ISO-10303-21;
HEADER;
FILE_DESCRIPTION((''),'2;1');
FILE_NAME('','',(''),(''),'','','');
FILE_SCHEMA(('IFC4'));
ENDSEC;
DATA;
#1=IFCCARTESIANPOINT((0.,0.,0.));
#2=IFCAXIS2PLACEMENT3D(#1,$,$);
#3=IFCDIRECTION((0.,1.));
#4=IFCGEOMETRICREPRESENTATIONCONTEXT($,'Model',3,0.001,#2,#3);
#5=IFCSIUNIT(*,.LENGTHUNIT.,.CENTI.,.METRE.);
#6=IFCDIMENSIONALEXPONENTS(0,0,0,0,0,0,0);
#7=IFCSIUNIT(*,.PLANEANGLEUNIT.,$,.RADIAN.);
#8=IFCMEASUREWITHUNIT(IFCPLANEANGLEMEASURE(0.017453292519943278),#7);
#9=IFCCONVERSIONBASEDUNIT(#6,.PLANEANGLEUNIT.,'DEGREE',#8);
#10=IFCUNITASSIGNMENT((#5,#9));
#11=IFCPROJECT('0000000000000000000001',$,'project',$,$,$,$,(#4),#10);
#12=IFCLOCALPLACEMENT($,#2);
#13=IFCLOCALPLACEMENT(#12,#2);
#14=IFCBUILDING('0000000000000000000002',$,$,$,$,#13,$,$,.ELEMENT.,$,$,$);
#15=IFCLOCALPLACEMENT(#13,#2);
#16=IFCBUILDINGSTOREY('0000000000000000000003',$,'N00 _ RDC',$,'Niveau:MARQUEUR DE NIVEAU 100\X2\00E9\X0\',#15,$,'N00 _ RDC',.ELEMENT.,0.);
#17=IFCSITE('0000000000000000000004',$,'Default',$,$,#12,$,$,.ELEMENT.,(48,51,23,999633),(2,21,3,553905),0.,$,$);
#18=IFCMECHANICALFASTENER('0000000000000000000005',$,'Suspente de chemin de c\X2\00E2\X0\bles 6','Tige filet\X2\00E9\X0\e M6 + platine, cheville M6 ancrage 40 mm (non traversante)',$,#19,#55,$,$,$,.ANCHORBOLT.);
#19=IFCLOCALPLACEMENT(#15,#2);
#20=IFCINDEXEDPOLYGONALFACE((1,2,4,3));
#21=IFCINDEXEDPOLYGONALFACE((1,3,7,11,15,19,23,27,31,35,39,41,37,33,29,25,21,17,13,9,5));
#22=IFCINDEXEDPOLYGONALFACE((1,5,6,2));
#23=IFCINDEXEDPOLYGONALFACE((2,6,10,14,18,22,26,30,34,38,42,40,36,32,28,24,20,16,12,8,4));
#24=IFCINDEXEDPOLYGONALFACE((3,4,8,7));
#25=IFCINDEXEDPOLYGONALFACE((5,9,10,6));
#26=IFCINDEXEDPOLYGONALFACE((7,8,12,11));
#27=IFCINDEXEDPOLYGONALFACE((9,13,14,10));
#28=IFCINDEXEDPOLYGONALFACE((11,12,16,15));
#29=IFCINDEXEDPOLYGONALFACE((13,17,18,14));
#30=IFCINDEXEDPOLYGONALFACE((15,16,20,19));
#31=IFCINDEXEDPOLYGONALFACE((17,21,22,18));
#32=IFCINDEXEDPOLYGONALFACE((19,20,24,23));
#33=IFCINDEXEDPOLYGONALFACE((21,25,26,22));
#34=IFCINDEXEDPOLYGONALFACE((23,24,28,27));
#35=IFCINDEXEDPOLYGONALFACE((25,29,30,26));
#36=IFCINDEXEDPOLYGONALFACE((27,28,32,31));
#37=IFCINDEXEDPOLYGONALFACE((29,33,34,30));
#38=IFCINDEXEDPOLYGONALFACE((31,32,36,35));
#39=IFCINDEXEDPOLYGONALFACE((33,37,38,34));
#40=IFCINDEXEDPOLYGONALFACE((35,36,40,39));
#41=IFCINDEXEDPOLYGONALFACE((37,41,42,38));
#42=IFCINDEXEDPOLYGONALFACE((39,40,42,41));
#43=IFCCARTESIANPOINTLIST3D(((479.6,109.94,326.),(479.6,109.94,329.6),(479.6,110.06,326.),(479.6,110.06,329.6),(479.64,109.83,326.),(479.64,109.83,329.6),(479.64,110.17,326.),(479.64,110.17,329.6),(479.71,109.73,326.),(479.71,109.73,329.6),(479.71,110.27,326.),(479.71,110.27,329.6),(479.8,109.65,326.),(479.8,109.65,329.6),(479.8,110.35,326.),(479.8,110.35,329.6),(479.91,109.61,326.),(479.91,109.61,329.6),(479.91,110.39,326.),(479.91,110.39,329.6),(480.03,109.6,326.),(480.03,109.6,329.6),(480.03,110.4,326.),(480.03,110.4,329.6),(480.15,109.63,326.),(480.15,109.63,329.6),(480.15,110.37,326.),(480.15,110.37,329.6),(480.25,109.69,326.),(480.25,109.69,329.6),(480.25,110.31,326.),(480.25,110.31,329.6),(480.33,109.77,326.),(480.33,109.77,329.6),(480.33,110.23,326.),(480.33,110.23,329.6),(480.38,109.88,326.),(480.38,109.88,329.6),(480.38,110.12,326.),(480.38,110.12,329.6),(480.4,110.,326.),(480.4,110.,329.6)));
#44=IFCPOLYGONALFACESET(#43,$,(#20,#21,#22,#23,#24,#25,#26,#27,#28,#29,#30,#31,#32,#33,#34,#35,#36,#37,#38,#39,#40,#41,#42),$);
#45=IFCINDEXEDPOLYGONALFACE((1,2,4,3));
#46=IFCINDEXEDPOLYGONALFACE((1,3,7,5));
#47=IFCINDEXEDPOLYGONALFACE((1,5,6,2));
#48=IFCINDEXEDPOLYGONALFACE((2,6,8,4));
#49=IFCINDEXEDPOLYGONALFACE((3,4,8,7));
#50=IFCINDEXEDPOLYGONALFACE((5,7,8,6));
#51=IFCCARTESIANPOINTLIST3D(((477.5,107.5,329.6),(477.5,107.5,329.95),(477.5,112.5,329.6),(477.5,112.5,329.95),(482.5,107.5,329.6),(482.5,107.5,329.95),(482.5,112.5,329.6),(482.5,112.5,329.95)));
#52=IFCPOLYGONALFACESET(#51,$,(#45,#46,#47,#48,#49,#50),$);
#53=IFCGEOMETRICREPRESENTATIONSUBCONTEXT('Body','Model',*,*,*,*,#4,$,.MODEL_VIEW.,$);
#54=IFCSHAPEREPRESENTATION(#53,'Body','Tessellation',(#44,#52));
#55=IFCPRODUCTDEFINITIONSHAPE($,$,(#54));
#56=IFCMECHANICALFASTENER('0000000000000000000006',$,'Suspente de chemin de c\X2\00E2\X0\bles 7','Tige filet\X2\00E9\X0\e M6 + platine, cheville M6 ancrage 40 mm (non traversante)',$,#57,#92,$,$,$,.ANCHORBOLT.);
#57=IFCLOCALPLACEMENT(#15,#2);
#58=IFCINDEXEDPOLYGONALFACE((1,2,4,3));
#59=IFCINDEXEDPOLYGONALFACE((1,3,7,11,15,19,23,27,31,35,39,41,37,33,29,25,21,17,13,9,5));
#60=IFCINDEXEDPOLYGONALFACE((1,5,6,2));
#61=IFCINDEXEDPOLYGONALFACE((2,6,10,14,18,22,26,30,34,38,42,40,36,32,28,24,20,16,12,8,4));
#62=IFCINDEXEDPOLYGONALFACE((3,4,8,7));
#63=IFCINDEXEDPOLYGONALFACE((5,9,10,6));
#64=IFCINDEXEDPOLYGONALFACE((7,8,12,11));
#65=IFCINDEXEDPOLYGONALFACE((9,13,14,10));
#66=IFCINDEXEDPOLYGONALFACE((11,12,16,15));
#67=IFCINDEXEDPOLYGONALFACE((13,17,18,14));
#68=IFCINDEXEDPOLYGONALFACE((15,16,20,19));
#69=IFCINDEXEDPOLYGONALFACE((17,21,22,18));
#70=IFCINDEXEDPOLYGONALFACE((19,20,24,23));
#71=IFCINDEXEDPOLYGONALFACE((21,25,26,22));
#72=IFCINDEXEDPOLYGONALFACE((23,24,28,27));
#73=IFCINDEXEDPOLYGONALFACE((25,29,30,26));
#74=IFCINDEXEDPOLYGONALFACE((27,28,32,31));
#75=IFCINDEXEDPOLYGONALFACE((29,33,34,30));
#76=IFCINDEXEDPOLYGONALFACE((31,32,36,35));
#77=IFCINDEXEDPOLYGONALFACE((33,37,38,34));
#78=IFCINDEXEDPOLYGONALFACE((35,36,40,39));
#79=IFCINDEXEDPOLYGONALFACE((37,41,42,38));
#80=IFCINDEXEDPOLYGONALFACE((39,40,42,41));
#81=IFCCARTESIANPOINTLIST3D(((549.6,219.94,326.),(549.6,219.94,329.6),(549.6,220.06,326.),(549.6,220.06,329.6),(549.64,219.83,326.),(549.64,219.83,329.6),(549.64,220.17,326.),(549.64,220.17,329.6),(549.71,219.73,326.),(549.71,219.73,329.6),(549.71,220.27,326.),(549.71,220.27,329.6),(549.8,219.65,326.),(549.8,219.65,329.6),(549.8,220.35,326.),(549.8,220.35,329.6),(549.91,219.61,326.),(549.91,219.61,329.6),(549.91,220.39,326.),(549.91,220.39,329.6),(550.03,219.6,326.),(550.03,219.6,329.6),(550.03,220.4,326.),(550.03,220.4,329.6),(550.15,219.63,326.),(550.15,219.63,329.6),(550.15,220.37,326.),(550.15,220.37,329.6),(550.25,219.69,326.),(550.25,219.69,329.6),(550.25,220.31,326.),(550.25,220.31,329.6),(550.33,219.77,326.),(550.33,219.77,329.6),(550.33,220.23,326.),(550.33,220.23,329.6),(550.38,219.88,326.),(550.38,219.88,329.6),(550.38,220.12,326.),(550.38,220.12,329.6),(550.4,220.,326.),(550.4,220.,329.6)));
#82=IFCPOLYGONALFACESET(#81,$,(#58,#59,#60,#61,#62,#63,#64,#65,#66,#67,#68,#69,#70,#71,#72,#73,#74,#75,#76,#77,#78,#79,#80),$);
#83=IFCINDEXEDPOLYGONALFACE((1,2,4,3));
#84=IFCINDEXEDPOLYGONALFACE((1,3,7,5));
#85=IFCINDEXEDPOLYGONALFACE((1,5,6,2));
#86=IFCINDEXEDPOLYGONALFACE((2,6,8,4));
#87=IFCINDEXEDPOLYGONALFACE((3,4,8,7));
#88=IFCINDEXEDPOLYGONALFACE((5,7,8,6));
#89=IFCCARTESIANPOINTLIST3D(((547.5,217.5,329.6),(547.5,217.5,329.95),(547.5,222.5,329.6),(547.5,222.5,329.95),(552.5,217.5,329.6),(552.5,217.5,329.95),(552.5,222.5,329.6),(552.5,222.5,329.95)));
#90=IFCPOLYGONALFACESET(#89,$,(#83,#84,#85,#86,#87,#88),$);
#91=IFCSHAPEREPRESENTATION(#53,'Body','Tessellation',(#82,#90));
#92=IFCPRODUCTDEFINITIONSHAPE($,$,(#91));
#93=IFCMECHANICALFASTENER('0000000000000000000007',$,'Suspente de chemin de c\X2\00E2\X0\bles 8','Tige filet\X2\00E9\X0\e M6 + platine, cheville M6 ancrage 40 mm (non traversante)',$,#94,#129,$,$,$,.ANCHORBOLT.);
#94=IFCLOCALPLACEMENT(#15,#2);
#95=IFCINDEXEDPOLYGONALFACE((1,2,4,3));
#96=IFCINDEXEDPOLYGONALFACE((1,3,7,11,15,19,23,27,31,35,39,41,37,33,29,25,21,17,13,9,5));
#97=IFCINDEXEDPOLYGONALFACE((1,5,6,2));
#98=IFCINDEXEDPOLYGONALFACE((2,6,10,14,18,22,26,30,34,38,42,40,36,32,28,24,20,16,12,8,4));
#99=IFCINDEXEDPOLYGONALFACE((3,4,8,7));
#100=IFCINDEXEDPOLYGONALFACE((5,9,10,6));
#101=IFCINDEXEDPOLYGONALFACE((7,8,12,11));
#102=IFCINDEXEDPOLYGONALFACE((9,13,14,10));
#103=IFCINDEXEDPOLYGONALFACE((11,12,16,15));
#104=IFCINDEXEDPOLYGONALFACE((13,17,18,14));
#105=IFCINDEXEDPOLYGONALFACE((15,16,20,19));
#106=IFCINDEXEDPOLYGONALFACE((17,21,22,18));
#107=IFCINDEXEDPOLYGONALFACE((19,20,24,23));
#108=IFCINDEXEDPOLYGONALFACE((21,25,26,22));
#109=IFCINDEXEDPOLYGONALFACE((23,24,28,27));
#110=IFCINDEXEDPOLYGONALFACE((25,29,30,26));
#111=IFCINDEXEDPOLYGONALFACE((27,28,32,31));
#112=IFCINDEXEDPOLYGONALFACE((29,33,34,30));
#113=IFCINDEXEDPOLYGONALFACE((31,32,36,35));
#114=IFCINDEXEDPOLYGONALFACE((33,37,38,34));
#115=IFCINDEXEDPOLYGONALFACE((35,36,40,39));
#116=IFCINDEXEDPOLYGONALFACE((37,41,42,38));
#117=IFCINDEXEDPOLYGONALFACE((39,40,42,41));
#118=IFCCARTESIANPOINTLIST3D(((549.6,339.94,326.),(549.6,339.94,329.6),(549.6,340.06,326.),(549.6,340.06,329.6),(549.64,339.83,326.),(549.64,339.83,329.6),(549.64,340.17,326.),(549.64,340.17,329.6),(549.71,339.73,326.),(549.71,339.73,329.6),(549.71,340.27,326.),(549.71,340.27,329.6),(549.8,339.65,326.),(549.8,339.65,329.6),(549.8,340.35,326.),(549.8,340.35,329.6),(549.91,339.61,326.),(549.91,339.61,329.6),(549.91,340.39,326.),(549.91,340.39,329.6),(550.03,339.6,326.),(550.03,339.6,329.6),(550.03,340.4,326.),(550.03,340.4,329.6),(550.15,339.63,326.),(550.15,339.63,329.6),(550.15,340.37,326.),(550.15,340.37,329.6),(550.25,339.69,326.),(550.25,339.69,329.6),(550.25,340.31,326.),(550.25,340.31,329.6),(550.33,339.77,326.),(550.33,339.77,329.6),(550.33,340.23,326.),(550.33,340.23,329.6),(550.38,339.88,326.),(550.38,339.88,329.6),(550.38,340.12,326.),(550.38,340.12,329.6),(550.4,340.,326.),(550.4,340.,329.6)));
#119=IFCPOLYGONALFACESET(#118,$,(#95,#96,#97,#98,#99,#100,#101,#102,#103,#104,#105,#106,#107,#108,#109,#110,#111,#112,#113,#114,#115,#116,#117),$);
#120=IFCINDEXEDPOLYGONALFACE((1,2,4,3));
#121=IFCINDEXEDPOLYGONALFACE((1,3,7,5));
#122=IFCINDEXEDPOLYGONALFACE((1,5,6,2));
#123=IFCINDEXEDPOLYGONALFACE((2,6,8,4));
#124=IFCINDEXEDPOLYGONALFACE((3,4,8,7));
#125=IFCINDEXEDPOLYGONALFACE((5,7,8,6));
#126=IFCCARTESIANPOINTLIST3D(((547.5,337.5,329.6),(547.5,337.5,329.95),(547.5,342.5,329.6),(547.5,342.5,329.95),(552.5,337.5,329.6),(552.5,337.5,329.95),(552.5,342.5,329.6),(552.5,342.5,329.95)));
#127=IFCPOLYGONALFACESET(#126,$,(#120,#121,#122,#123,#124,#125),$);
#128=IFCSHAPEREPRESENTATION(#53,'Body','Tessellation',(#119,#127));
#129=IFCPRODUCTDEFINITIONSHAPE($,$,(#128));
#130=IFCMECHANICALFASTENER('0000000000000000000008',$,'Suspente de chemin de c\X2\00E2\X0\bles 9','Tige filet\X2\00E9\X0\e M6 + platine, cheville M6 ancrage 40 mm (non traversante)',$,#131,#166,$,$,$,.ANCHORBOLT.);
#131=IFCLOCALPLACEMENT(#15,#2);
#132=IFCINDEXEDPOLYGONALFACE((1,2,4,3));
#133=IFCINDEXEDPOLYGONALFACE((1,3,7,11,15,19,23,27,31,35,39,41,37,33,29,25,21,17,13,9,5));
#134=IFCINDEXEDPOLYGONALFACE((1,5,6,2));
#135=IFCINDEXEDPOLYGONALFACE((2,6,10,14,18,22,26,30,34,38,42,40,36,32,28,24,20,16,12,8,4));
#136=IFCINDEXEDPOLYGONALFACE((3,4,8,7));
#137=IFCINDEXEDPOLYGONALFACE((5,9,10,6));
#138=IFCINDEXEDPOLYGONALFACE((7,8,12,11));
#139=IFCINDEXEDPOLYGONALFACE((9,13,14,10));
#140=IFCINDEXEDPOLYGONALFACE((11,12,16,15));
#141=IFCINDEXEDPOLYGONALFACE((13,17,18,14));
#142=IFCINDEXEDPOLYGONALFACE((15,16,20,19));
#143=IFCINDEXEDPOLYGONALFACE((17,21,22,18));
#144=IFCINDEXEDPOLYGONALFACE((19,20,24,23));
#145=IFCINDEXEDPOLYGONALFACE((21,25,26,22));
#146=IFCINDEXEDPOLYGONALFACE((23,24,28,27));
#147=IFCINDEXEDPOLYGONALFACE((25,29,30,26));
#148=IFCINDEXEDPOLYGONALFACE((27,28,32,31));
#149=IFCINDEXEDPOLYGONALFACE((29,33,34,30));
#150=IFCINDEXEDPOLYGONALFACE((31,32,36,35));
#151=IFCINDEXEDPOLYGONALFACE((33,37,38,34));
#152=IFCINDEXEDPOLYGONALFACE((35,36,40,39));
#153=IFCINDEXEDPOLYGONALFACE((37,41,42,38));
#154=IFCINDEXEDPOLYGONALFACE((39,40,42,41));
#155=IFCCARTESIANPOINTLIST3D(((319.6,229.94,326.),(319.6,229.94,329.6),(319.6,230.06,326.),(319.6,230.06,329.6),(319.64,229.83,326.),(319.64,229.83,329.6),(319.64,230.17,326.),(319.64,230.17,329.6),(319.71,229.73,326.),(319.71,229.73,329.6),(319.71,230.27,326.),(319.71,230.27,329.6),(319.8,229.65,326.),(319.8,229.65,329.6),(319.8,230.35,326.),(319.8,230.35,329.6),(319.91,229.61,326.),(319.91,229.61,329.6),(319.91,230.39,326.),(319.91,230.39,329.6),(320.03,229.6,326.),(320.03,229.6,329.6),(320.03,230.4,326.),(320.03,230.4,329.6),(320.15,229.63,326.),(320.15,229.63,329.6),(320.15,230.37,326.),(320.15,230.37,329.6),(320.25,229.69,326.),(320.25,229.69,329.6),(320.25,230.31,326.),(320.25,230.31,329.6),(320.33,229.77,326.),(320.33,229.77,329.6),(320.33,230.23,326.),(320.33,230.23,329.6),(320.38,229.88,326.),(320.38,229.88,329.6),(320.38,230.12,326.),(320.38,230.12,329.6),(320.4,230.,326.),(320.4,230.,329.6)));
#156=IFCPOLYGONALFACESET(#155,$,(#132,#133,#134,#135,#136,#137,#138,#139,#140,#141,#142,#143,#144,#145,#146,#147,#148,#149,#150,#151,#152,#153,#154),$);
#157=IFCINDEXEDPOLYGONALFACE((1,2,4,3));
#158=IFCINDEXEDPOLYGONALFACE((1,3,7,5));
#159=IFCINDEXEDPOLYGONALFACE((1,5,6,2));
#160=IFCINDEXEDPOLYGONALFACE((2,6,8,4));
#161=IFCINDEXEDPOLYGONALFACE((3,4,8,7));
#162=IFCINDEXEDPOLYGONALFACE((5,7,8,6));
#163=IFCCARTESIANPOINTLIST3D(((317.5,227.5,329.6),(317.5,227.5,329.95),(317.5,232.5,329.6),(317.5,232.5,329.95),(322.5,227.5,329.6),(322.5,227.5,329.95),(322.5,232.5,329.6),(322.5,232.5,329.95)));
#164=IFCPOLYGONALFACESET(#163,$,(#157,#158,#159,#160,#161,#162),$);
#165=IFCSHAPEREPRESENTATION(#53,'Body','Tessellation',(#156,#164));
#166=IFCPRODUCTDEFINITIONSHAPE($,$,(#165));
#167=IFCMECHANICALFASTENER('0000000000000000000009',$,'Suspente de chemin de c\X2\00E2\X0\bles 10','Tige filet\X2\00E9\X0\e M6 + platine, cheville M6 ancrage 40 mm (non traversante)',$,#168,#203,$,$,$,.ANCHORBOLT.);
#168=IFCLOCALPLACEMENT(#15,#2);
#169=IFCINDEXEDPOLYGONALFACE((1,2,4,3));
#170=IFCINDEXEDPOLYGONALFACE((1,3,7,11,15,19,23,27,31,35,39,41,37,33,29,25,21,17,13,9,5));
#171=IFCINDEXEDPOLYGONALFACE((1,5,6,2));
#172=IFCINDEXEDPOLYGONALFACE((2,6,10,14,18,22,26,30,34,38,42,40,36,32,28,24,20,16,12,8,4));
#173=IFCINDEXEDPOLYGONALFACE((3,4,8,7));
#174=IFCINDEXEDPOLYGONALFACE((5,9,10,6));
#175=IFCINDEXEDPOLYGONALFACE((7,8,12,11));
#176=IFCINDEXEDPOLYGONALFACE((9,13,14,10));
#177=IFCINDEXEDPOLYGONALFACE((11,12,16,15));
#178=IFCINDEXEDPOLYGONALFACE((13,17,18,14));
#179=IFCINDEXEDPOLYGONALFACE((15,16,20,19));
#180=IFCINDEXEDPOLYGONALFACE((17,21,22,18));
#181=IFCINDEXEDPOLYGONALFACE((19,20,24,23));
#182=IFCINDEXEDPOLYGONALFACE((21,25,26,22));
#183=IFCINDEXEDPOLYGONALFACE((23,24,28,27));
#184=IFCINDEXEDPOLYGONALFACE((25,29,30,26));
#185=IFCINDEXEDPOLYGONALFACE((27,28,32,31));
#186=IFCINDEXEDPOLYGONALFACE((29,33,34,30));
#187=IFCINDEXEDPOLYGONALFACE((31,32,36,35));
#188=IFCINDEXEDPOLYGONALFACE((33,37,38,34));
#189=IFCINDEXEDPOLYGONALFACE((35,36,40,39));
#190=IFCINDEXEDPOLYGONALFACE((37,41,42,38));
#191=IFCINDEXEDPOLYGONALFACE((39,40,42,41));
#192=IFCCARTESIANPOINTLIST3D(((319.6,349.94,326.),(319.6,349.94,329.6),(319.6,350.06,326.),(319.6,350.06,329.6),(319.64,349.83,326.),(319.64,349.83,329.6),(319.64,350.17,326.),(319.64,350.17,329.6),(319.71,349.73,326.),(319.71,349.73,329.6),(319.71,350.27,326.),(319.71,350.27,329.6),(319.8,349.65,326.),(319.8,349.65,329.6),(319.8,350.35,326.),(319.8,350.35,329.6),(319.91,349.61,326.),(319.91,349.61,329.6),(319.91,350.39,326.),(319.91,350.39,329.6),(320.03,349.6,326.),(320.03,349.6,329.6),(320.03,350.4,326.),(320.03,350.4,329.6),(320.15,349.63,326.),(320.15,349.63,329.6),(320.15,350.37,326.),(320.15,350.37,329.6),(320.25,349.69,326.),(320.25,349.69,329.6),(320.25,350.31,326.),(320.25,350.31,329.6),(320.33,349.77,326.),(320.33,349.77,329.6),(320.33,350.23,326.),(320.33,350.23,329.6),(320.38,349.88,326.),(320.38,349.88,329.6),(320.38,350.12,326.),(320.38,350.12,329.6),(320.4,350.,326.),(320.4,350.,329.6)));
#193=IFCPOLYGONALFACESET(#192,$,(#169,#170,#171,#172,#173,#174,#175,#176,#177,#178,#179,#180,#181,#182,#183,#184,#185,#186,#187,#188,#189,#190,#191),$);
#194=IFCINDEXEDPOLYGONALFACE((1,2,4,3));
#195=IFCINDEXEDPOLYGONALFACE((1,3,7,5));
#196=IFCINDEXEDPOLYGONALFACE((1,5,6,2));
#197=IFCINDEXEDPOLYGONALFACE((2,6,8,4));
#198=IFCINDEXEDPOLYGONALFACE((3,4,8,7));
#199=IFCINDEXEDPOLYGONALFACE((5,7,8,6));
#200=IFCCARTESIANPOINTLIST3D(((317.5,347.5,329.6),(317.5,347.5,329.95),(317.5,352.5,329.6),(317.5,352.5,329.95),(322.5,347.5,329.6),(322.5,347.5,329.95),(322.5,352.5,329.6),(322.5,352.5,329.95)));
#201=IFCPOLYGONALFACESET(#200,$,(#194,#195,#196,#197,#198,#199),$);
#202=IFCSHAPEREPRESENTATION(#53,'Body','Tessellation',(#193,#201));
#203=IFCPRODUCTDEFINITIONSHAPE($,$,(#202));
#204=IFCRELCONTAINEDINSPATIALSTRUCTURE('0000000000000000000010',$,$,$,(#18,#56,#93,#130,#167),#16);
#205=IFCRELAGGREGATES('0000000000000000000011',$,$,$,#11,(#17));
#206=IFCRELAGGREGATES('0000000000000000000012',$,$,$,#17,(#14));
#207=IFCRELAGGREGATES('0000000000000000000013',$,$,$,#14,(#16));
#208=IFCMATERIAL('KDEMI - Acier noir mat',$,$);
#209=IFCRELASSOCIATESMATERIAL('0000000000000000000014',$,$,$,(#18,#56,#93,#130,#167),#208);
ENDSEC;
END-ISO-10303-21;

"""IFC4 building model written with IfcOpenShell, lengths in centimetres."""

from ifc_helpers import new_model, entity, si_unit, converted_unit, direction, frame, frame_2d, origin, origin_with_axes, place, context, subcontext, project, spatial, rectangle, circle, extrude, material, element, save


model = new_model("IFC4")

# Units and contexts
model_context = context("Model", 3, precision=0.001, world=origin(), true_north=direction((0.0, 1.0)))
body_context = subcontext(model_context, "Body", "Model", "MODEL_VIEW")
ifc_project = project(units=[si_unit("LENGTHUNIT", "METRE", prefix="CENTI"), converted_unit("PLANEANGLEUNIT", "DEGREE", entity("IfcPlaneAngleMeasure", 0.017453292519943278), si_unit("PLANEANGLEUNIT", "RADIAN"), dimensions=[0, 0, 0, 0, 0, 0, 0])], contexts=[model_context])

# Site, building, storey
site_placement = place(None, origin())
site = spatial("IfcSite", under=ifc_project, at=site_placement, Name="Default", CompositionType="ELEMENT", RefLatitude=(48, 51, 23, 999633), RefLongitude=(2, 21, 3, 553905), RefElevation=0.0)
building_placement = place(site_placement, origin())
building = spatial("IfcBuilding", under=site, at=building_placement, CompositionType="ELEMENT")
storey_placement = place(building_placement, origin())
storey = spatial("IfcBuildingStorey", under=building, at=storey_placement, Name="N00 _ RDC", ObjectType="Niveau:MARQUEUR DE NIVEAU 100é", LongName="N00 _ RDC", CompositionType="ELEMENT", Elevation=0.0)

# Shared definitions
ifc_material_1 = material(Name="KDEMI - Acier noir mat")

# Mechanical fasteners
mechanical_fastener_1_placement = place(storey_placement, origin_with_axes())
element("IfcMechanicalFastener", 1, at=mechanical_fastener_1_placement, inside=storey, material=ifc_material_1, Name="Suspente de chemin de câbles 6", Description="Tige filetée M6 + platine, cheville M6 ancrage 40 mm (non traversante)", PredefinedType="ANCHORBOLT", context=body_context, shape_type="SweptSolid", body=[
    extrude(circle(Radius=0.4, at=frame_2d((480.0, 110.0))), frame((0.0, 0.0, 326.0)), (0.0, 0.0, 1.0), 3.6),
    extrude(rectangle(XDim=5.0, YDim=5.0, at=frame_2d((480.0, 110.0))), frame((0.0, 0.0, 329.6)), (0.0, 0.0, 1.0), 0.35),
])
mechanical_fastener_2_placement = place(storey_placement, origin_with_axes())
element("IfcMechanicalFastener", 2, at=mechanical_fastener_2_placement, inside=storey, material=ifc_material_1, Name="Suspente de chemin de câbles 7", Description="Tige filetée M6 + platine, cheville M6 ancrage 40 mm (non traversante)", PredefinedType="ANCHORBOLT", context=body_context, shape_type="SweptSolid", body=[
    extrude(circle(Radius=0.4, at=frame_2d((550.0, 220.0))), frame((0.0, 0.0, 326.0)), (0.0, 0.0, 1.0), 3.6),
    extrude(rectangle(XDim=5.0, YDim=5.0, at=frame_2d((550.0, 220.0))), frame((0.0, 0.0, 329.6)), (0.0, 0.0, 1.0), 0.35),
])
mechanical_fastener_3_placement = place(storey_placement, origin_with_axes())
element("IfcMechanicalFastener", 3, at=mechanical_fastener_3_placement, inside=storey, material=ifc_material_1, Name="Suspente de chemin de câbles 8", Description="Tige filetée M6 + platine, cheville M6 ancrage 40 mm (non traversante)", PredefinedType="ANCHORBOLT", context=body_context, shape_type="SweptSolid", body=[
    extrude(circle(Radius=0.4, at=frame_2d((550.0, 340.0))), frame((0.0, 0.0, 326.0)), (0.0, 0.0, 1.0), 3.6),
    extrude(rectangle(XDim=5.0, YDim=5.0, at=frame_2d((550.0, 340.0))), frame((0.0, 0.0, 329.6)), (0.0, 0.0, 1.0), 0.35),
])
mechanical_fastener_4_placement = place(storey_placement, origin_with_axes())
element("IfcMechanicalFastener", 4, at=mechanical_fastener_4_placement, inside=storey, material=ifc_material_1, Name="Suspente de chemin de câbles 9", Description="Tige filetée M6 + platine, cheville M6 ancrage 40 mm (non traversante)", PredefinedType="ANCHORBOLT", context=body_context, shape_type="SweptSolid", body=[
    extrude(circle(Radius=0.4, at=frame_2d((320.0, 230.0))), frame((0.0, 0.0, 326.0)), (0.0, 0.0, 1.0), 3.6),
    extrude(rectangle(XDim=5.0, YDim=5.0, at=frame_2d((320.0, 230.0))), frame((0.0, 0.0, 329.6)), (0.0, 0.0, 1.0), 0.35),
])
mechanical_fastener_5_placement = place(storey_placement, origin_with_axes())
element("IfcMechanicalFastener", 5, at=mechanical_fastener_5_placement, inside=storey, material=ifc_material_1, Name="Suspente de chemin de câbles 10", Description="Tige filetée M6 + platine, cheville M6 ancrage 40 mm (non traversante)", PredefinedType="ANCHORBOLT", context=body_context, shape_type="SweptSolid", body=[
    extrude(circle(Radius=0.4, at=frame_2d((320.0, 350.0))), frame((0.0, 0.0, 326.0)), (0.0, 0.0, 1.0), 3.6),
    extrude(rectangle(XDim=5.0, YDim=5.0, at=frame_2d((320.0, 350.0))), frame((0.0, 0.0, 329.6)), (0.0, 0.0, 1.0), 0.35),
])

save(model, "model.ifc")
